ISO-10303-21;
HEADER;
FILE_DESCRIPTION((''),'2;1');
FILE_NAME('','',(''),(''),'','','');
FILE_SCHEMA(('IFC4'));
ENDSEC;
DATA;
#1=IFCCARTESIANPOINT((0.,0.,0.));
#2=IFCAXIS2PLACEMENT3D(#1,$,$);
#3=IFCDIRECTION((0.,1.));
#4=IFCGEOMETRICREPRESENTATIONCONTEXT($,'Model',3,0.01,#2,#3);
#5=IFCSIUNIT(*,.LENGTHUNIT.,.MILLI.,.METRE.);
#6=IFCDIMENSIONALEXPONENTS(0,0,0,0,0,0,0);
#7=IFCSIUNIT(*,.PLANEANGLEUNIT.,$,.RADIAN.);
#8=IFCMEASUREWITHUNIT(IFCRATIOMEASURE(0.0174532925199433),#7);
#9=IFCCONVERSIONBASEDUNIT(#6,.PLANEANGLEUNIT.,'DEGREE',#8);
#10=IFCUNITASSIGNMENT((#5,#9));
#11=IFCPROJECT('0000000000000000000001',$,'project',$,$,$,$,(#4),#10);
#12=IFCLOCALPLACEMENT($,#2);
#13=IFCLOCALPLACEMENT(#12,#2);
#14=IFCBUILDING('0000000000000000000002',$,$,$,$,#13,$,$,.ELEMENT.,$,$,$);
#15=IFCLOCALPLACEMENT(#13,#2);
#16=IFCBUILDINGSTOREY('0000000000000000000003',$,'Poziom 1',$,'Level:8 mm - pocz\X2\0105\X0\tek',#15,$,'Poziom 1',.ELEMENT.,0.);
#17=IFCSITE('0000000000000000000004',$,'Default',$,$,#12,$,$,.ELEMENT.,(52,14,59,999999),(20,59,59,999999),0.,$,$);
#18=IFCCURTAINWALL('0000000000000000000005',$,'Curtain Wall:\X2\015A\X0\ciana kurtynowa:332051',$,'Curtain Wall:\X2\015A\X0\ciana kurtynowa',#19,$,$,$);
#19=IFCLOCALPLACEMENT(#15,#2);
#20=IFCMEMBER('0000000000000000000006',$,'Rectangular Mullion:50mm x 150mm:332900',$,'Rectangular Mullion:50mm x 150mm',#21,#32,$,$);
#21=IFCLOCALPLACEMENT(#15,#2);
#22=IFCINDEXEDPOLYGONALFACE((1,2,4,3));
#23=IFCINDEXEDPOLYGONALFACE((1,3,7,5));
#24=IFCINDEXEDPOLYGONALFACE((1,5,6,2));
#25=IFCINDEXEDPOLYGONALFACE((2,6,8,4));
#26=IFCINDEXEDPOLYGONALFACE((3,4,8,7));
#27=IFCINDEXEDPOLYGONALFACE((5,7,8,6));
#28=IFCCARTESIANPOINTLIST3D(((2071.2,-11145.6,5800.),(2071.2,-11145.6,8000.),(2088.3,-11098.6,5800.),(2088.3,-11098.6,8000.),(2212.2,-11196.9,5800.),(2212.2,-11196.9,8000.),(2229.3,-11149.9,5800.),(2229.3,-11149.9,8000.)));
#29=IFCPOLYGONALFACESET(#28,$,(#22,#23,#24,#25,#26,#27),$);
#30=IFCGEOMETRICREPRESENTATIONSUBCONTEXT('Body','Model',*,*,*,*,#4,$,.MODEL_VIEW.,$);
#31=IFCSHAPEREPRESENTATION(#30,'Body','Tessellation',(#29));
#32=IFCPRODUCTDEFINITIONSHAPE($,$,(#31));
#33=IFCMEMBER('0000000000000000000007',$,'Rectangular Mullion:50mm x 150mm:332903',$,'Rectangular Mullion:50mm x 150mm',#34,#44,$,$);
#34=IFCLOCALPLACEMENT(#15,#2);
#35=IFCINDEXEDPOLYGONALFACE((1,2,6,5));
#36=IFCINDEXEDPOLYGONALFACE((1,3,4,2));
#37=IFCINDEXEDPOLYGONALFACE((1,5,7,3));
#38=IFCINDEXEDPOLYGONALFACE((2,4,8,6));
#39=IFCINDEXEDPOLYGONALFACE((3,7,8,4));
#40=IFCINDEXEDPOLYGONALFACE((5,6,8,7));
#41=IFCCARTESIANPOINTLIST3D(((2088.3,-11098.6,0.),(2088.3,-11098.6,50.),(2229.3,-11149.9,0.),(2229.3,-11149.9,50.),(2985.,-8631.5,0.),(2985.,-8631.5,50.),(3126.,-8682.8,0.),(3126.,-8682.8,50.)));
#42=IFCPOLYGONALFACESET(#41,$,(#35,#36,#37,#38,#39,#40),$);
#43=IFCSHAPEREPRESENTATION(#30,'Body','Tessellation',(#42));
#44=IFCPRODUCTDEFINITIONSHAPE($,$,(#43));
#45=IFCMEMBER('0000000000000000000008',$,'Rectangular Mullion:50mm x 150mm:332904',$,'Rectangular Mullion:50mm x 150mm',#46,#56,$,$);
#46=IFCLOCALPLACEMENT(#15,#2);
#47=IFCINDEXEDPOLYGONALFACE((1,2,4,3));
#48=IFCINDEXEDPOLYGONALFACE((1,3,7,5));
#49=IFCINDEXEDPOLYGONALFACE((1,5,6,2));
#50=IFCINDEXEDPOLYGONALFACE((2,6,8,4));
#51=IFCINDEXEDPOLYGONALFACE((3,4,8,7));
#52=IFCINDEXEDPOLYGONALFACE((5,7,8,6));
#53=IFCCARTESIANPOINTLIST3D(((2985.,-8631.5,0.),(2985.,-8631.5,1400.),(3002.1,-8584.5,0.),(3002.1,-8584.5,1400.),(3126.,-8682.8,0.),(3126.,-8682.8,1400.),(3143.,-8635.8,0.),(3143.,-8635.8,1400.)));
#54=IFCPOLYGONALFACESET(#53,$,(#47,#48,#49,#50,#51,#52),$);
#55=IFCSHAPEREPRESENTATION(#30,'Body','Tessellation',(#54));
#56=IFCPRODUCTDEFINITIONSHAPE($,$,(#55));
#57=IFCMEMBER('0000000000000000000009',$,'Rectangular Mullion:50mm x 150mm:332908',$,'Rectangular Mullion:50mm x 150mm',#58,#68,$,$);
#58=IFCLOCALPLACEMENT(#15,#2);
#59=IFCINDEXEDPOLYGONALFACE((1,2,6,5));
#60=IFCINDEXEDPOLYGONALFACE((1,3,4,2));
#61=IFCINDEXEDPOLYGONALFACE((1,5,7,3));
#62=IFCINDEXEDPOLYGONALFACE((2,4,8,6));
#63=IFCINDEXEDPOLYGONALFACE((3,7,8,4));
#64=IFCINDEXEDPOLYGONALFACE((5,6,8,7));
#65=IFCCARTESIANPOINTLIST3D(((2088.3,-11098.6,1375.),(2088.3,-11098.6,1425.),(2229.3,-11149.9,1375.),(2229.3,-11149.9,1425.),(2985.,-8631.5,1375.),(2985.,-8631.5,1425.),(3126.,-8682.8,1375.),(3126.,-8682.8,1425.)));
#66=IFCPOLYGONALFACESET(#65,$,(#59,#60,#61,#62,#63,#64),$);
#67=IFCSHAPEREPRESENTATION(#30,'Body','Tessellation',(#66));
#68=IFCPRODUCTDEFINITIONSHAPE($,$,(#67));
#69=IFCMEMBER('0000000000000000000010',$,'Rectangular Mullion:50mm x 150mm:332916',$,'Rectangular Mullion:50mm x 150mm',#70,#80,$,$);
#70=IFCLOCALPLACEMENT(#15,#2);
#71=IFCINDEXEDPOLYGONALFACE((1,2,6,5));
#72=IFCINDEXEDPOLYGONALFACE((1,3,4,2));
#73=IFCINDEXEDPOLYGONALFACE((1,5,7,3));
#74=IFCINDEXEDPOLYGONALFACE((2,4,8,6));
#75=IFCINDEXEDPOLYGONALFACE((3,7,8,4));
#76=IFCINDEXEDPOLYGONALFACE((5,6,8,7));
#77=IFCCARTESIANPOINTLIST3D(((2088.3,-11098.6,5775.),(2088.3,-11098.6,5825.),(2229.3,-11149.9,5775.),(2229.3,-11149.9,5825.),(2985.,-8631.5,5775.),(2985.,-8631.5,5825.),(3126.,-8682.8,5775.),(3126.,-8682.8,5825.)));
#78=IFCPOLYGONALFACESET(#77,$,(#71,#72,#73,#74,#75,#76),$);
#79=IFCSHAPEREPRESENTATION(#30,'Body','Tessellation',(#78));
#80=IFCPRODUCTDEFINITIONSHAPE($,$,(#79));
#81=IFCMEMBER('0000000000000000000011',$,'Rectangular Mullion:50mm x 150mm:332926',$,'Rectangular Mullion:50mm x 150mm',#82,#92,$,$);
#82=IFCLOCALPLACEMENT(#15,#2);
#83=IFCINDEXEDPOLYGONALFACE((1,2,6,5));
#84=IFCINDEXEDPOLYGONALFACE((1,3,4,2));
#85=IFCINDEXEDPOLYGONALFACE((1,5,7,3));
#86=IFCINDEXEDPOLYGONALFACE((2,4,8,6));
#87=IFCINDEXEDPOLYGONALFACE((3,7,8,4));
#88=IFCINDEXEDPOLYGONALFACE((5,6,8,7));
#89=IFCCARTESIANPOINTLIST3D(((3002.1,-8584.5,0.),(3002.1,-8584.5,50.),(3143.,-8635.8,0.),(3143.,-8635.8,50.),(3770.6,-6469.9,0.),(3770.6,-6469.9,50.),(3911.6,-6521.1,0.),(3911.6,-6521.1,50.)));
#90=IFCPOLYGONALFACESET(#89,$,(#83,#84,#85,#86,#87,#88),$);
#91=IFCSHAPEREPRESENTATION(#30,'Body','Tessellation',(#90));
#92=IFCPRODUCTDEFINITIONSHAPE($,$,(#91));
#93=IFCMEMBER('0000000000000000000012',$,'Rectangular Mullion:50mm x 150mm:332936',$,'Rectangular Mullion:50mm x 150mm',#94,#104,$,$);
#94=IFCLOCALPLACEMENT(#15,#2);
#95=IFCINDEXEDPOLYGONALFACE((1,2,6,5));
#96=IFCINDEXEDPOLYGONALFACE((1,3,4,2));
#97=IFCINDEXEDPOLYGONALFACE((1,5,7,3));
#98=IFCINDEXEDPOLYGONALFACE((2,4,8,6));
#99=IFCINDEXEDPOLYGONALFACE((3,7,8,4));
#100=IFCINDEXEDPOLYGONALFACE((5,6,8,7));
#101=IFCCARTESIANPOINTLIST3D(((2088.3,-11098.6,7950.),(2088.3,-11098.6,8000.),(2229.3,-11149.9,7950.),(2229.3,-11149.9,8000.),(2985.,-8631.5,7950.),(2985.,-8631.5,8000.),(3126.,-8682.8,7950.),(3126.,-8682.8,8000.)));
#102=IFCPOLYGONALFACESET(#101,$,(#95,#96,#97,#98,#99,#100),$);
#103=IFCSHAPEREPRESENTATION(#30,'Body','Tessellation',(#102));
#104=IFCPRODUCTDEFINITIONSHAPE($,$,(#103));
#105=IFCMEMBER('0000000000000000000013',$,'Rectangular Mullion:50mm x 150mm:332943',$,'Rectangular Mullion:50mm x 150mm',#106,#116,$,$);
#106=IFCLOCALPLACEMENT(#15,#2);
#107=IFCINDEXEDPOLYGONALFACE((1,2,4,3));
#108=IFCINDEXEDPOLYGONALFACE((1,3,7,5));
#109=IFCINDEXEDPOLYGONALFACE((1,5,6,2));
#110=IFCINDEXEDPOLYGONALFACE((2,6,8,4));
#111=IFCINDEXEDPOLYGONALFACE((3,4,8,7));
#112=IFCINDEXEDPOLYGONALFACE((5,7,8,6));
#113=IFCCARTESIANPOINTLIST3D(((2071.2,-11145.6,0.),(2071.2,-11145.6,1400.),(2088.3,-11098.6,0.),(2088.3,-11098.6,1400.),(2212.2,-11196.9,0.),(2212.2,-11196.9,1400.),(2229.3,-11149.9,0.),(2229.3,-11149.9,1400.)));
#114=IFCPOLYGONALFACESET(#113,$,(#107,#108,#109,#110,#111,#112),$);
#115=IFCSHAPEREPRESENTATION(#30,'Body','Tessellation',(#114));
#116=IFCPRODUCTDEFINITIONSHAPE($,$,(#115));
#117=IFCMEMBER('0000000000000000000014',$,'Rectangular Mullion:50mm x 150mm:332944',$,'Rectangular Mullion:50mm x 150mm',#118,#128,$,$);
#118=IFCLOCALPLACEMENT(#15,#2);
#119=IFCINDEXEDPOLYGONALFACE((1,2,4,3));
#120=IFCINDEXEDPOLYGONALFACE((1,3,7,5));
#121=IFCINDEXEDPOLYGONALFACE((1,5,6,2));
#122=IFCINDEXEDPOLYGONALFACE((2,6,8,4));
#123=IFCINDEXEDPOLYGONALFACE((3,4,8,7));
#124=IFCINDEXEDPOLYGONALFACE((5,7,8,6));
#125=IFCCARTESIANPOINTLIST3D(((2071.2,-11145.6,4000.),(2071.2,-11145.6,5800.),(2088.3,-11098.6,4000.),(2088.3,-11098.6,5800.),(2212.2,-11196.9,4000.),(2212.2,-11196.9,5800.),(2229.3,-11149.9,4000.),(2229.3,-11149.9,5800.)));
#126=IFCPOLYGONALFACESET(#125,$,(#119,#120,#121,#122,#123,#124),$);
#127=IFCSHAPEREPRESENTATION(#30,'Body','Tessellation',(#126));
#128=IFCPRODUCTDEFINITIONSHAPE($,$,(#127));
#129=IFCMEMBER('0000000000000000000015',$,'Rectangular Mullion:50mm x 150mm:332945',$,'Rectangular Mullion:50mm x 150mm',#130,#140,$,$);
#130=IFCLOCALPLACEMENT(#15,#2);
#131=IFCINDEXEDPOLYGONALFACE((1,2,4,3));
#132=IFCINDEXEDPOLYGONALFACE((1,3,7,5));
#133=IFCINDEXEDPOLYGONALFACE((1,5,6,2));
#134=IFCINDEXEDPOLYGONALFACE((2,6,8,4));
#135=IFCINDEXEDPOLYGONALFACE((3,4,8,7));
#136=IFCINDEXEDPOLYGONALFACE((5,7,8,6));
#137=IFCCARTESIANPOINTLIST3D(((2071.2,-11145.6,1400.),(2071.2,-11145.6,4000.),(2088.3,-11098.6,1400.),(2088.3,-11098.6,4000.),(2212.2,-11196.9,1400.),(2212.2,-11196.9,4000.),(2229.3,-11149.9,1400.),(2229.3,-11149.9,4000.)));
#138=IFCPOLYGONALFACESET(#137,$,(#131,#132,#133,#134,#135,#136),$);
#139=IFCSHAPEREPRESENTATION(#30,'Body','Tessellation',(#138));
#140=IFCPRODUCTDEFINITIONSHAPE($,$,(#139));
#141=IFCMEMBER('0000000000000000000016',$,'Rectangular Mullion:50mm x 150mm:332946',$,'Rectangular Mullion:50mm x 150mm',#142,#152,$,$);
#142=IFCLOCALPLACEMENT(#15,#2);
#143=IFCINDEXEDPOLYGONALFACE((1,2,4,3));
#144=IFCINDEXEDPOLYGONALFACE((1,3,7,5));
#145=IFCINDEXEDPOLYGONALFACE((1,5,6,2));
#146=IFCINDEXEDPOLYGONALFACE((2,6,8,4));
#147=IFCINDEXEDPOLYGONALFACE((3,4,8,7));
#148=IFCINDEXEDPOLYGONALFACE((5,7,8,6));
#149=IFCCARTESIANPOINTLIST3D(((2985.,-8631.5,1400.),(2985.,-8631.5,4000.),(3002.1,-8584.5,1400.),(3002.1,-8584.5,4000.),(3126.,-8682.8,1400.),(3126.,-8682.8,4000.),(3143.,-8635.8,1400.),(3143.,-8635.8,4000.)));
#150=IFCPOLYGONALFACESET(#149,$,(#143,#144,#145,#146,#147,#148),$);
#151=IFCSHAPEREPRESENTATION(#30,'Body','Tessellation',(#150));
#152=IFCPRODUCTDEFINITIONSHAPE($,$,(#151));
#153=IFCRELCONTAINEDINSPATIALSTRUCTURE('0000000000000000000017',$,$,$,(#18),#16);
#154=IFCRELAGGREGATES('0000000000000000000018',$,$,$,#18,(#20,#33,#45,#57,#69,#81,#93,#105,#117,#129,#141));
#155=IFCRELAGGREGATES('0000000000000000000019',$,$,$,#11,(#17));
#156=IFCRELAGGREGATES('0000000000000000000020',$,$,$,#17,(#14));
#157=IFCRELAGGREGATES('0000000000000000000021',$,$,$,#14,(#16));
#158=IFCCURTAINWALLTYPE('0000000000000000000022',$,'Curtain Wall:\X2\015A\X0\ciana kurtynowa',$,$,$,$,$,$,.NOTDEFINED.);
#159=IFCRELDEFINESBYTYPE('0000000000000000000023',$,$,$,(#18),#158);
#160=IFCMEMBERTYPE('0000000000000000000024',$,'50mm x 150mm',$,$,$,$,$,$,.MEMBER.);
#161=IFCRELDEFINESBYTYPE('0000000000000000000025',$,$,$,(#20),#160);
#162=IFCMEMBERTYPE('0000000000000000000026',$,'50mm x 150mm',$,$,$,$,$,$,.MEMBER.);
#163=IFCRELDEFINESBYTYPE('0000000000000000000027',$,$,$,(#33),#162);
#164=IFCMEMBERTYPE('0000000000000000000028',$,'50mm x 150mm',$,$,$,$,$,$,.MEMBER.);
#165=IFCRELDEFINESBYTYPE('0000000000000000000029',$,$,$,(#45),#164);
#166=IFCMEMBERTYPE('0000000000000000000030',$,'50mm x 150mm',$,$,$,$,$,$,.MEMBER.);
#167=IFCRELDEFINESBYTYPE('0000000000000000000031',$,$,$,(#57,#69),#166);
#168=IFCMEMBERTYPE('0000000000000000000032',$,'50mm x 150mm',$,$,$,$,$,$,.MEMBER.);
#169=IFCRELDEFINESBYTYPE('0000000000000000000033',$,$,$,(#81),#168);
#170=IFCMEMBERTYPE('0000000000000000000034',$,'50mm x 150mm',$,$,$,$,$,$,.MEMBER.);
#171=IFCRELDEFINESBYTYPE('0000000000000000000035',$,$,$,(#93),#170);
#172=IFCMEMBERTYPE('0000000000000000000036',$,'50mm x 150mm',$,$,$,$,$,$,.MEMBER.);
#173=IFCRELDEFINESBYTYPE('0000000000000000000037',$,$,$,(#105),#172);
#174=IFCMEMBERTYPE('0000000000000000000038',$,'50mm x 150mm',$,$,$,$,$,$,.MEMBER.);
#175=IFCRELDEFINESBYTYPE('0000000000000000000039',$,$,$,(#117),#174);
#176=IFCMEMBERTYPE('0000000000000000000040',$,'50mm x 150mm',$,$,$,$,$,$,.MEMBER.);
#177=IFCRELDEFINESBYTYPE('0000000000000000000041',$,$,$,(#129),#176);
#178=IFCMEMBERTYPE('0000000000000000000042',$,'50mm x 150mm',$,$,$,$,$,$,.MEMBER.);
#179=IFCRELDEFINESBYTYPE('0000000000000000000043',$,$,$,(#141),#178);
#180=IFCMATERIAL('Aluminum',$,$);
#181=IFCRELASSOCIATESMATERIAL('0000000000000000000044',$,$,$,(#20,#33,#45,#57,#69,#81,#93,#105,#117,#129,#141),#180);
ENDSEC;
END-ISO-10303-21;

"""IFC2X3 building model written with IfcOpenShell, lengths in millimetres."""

from ifc_helpers import new_model, entity, si_unit, converted_unit, direction, frame, origin, origin_2d_with_axis, place, context, subcontext, project, spatial, rectangle, extrude, source, transform, mapped, material, type_object, type_shapes, element, aggregate, save


model = new_model("IFC2X3")

# Units and contexts
model_context = context("Model", 3, precision=0.01, world=origin(), true_north=direction((0.0, 1.0)))
body_context = subcontext(model_context, "Body", "Model", "MODEL_VIEW")
ifc_project = project(units=[si_unit("LENGTHUNIT", "METRE", prefix="MILLI"), converted_unit("PLANEANGLEUNIT", "DEGREE", entity("IfcRatioMeasure", 0.0174532925199433), si_unit("PLANEANGLEUNIT", "RADIAN"), dimensions=[0, 0, 0, 0, 0, 0, 0])], contexts=[model_context])

# Site, building, storey
site_placement = place(None, origin())
site = spatial("IfcSite", under=ifc_project, at=site_placement, Name="Default", CompositionType="ELEMENT", RefLatitude=(52, 14, 59, 999999), RefLongitude=(20, 59, 59, 999999), RefElevation=0.0)
building_placement = place(site_placement, origin())
building = spatial("IfcBuilding", under=site, at=building_placement, CompositionType="ELEMENT")
storey_placement = place(building_placement, origin())
storey = spatial("IfcBuildingStorey", under=building, at=storey_placement, Name="Poziom 1", ObjectType="Level:8 mm - początek", LongName="Poziom 1", CompositionType="ELEMENT", Elevation=0.0)

# Curtain wall, members
curtain_wall_type = type_object("IfcCurtainWallType", Name="Curtain Wall:Ściana kurtynowa", PredefinedType="NOTDEFINED")
curtain_wall_placement = place(storey_placement, origin())
curtain_wall = element("IfcCurtainWall", 1, at=curtain_wall_placement, inside=storey, type_object=curtain_wall_type, Name="Curtain Wall:Ściana kurtynowa:332051", ObjectType="Curtain Wall:Ściana kurtynowa")
ifc_material_1 = material(Name="Aluminum")
member_type_1 = type_object("IfcMemberType", Name="50mm x 150mm", PredefinedType="MEMBER")
shared_shape_1 = source(origin(), body_context, "Body", "SweptSolid", [
    extrude(rectangle(XDim=150.0, YDim=50.0, at=origin_2d_with_axis()), frame((-25.0, 0.0, -2200.0), z_axis=(0.0, 0.0, 1.0), x_axis=(0.0, -1.0, 0.0)), (0.0, 0.0, 1.0), 2200.0),
])
type_shapes(member_type_1, [shared_shape_1])
member_1_placement = place(storey_placement, frame((2141.7, -11171.2, 8000.0), z_axis=(0.0, 0.0, 1.0), x_axis=(-0.341586, -0.939851, 0.0)))
member_1 = element("IfcMember", 2, at=member_1_placement, type_object=member_type_1, material=ifc_material_1, Name="Rectangular Mullion:50mm x 150mm:332900", ObjectType="Rectangular Mullion:50mm x 150mm", context=body_context, shape_type="MappedRepresentation", body=[
    mapped(shared_shape_1, transform((0.0, 0.0, 0.0), scale=1.0)),
])
member_type_2 = type_object("IfcMemberType", Name="50mm x 150mm", PredefinedType="MEMBER")
shared_shape_2 = source(origin(), body_context, "Body", "SweptSolid", [
    extrude(rectangle(XDim=150.0, YDim=50.0, at=origin_2d_with_axis()), frame((-25.0, 0.0, -2625.0), z_axis=(0.0, 0.0, 1.0), x_axis=(0.0, -1.0, 0.0)), (0.0, 0.0, 1.0), 2625.0),
])
type_shapes(member_type_2, [shared_shape_2])
member_2_placement = place(storey_placement, frame((2158.8, -11124.3, 0.0), z_axis=(-0.341586, -0.939851, 0.0), x_axis=(0.0, 0.0, -1.0)))
member_2 = element("IfcMember", 3, at=member_2_placement, type_object=member_type_2, material=ifc_material_1, Name="Rectangular Mullion:50mm x 150mm:332903", ObjectType="Rectangular Mullion:50mm x 150mm", context=body_context, shape_type="MappedRepresentation", body=[
    mapped(shared_shape_2, transform((0.0, 0.0, 0.0), scale=1.0)),
])
member_type_3 = type_object("IfcMemberType", Name="50mm x 150mm", PredefinedType="MEMBER")
shared_shape_3 = source(origin(), body_context, "Body", "SweptSolid", [
    extrude(rectangle(XDim=150.0, YDim=50.0, at=origin_2d_with_axis()), frame((0.0, 0.0, -1400.0), z_axis=(0.0, 0.0, 1.0), x_axis=(0.0, -1.0, 0.0)), (0.0, 0.0, 1.0), 1400.0),
])
type_shapes(member_type_3, [shared_shape_3])
member_3_placement = place(storey_placement, frame((3064.0, -8633.7, 0.0), z_axis=(0.0, 0.0, -1.0), x_axis=(0.341586, 0.939851, 0.0)))
member_3 = element("IfcMember", 4, at=member_3_placement, type_object=member_type_3, material=ifc_material_1, Name="Rectangular Mullion:50mm x 150mm:332904", ObjectType="Rectangular Mullion:50mm x 150mm", context=body_context, shape_type="MappedRepresentation", body=[
    mapped(shared_shape_3, transform((0.0, 0.0, 0.0), scale=1.0)),
])
member_type_4 = type_object("IfcMemberType", Name="50mm x 150mm", PredefinedType="MEMBER")
shared_shape_4 = source(origin(), body_context, "Body", "SweptSolid", [
    extrude(rectangle(XDim=150.0, YDim=50.0, at=origin_2d_with_axis()), frame((0.0, 0.0, -2625.0), z_axis=(0.0, 0.0, 1.0), x_axis=(0.0, -1.0, 0.0)), (0.0, 0.0, 1.0), 2625.0),
])
type_shapes(member_type_4, [shared_shape_4])
member_4_placement = place(storey_placement, frame((3055.5, -8657.1, 1400.0), z_axis=(0.341586, 0.939851, 0.0), x_axis=(0.0, 0.0, 1.0)))
member_4 = element("IfcMember", 5, at=member_4_placement, type_object=member_type_4, material=ifc_material_1, Name="Rectangular Mullion:50mm x 150mm:332908", ObjectType="Rectangular Mullion:50mm x 150mm", context=body_context, shape_type="MappedRepresentation", body=[
    mapped(shared_shape_4, transform((0.0, 0.0, 0.0), scale=1.0)),
])
member_5_placement = place(storey_placement, frame((3055.5, -8657.1, 5800.0), z_axis=(0.341586, 0.939851, 0.0), x_axis=(0.0, 0.0, 1.0)))
member_5 = element("IfcMember", 6, at=member_5_placement, type_object=member_type_4, material=ifc_material_1, Name="Rectangular Mullion:50mm x 150mm:332916", ObjectType="Rectangular Mullion:50mm x 150mm", context=body_context, shape_type="MappedRepresentation", body=[
    mapped(shared_shape_4, transform((0.0, 0.0, 0.0), scale=1.0)),
])
member_type_5 = type_object("IfcMemberType", Name="50mm x 150mm", PredefinedType="MEMBER")
shared_shape_5 = source(origin(), body_context, "Body", "SweptSolid", [
    extrude(rectangle(XDim=150.0, YDim=50.0, at=origin_2d_with_axis()), frame((-25.0, 0.0, -2250.0), z_axis=(0.0, 0.0, 1.0), x_axis=(0.0, -1.0, 0.0)), (0.0, 0.0, 1.0), 2250.0),
])
type_shapes(member_type_5, [shared_shape_5])
member_6_placement = place(storey_placement, frame((3072.5, -8610.2, 0.0), z_axis=(-0.341586, -0.939851, 0.0), x_axis=(0.0, 0.0, -1.0)))
member_6 = element("IfcMember", 7, at=member_6_placement, type_object=member_type_5, material=ifc_material_1, Name="Rectangular Mullion:50mm x 150mm:332926", ObjectType="Rectangular Mullion:50mm x 150mm", context=body_context, shape_type="MappedRepresentation", body=[
    mapped(shared_shape_5, transform((0.0, 0.0, 0.0), scale=1.0)),
])
member_type_6 = type_object("IfcMemberType", Name="50mm x 150mm", PredefinedType="MEMBER")
shared_shape_6 = source(origin(), body_context, "Body", "SweptSolid", [
    extrude(rectangle(XDim=150.0, YDim=50.0, at=origin_2d_with_axis()), frame((-25.0, 0.0, -2625.0), z_axis=(0.0, 0.0, 1.0), x_axis=(0.0, -1.0, 0.0)), (0.0, 0.0, 1.0), 2625.0),
])
type_shapes(member_type_6, [shared_shape_6])
member_7_placement = place(storey_placement, frame((3055.5, -8657.1, 8000.0), z_axis=(0.341586, 0.939851, 0.0), x_axis=(0.0, 0.0, 1.0)))
member_7 = element("IfcMember", 8, at=member_7_placement, type_object=member_type_6, material=ifc_material_1, Name="Rectangular Mullion:50mm x 150mm:332936", ObjectType="Rectangular Mullion:50mm x 150mm", context=body_context, shape_type="MappedRepresentation", body=[
    mapped(shared_shape_6, transform((0.0, 0.0, 0.0), scale=1.0)),
])
member_type_7 = type_object("IfcMemberType", Name="50mm x 150mm", PredefinedType="MEMBER")
shared_shape_7 = source(origin(), body_context, "Body", "SweptSolid", [
    extrude(rectangle(XDim=150.0, YDim=50.0, at=origin_2d_with_axis()), frame((-25.0, 0.0, -1400.0), z_axis=(0.0, 0.0, 1.0), x_axis=(0.0, -1.0, 0.0)), (0.0, 0.0, 1.0), 1400.0),
])
type_shapes(member_type_7, [shared_shape_7])
member_8_placement = place(storey_placement, frame((2141.7, -11171.2, 1400.0), z_axis=(0.0, 0.0, 1.0), x_axis=(-0.341586, -0.939851, 0.0)))
member_8 = element("IfcMember", 9, at=member_8_placement, type_object=member_type_7, material=ifc_material_1, Name="Rectangular Mullion:50mm x 150mm:332943", ObjectType="Rectangular Mullion:50mm x 150mm", context=body_context, shape_type="MappedRepresentation", body=[
    mapped(shared_shape_7, transform((0.0, 0.0, 0.0), scale=1.0)),
])
member_type_8 = type_object("IfcMemberType", Name="50mm x 150mm", PredefinedType="MEMBER")
shared_shape_8 = source(origin(), body_context, "Body", "SweptSolid", [
    extrude(rectangle(XDim=150.0, YDim=50.0, at=origin_2d_with_axis()), frame((-25.0, 0.0, -1800.0), z_axis=(0.0, 0.0, 1.0), x_axis=(0.0, -1.0, 0.0)), (0.0, 0.0, 1.0), 1800.0),
])
type_shapes(member_type_8, [shared_shape_8])
member_9_placement = place(storey_placement, frame((2141.7, -11171.2, 5800.0), z_axis=(0.0, 0.0, 1.0), x_axis=(-0.341586, -0.939851, 0.0)))
member_9 = element("IfcMember", 10, at=member_9_placement, type_object=member_type_8, material=ifc_material_1, Name="Rectangular Mullion:50mm x 150mm:332944", ObjectType="Rectangular Mullion:50mm x 150mm", context=body_context, shape_type="MappedRepresentation", body=[
    mapped(shared_shape_8, transform((0.0, 0.0, 0.0), scale=1.0)),
])
member_type_9 = type_object("IfcMemberType", Name="50mm x 150mm", PredefinedType="MEMBER")
shared_shape_9 = source(origin(), body_context, "Body", "SweptSolid", [
    extrude(rectangle(XDim=150.0, YDim=50.0, at=origin_2d_with_axis()), frame((-25.0, 0.0, -2600.0), z_axis=(0.0, 0.0, 1.0), x_axis=(0.0, -1.0, 0.0)), (0.0, 0.0, 1.0), 2600.0),
])
type_shapes(member_type_9, [shared_shape_9])
member_10_placement = place(storey_placement, frame((2141.7, -11171.2, 4000.0), z_axis=(0.0, 0.0, 1.0), x_axis=(-0.341586, -0.939851, 0.0)))
member_10 = element("IfcMember", 11, at=member_10_placement, type_object=member_type_9, material=ifc_material_1, Name="Rectangular Mullion:50mm x 150mm:332945", ObjectType="Rectangular Mullion:50mm x 150mm", context=body_context, shape_type="MappedRepresentation", body=[
    mapped(shared_shape_9, transform((0.0, 0.0, 0.0), scale=1.0)),
])
member_type_10 = type_object("IfcMemberType", Name="50mm x 150mm", PredefinedType="MEMBER")
shared_shape_10 = source(origin(), body_context, "Body", "SweptSolid", [
    extrude(rectangle(XDim=150.0, YDim=50.0, at=origin_2d_with_axis()), frame((0.0, 0.0, -2600.0), z_axis=(0.0, 0.0, 1.0), x_axis=(0.0, -1.0, 0.0)), (0.0, 0.0, 1.0), 2600.0),
])
type_shapes(member_type_10, [shared_shape_10])
member_11_placement = place(storey_placement, frame((3064.0, -8633.7, 1400.0), z_axis=(0.0, 0.0, -1.0), x_axis=(0.341586, 0.939851, 0.0)))
member_11 = element("IfcMember", 12, at=member_11_placement, type_object=member_type_10, material=ifc_material_1, Name="Rectangular Mullion:50mm x 150mm:332946", ObjectType="Rectangular Mullion:50mm x 150mm", context=body_context, shape_type="MappedRepresentation", body=[
    mapped(shared_shape_10, transform((0.0, 0.0, 0.0), scale=1.0)),
])
aggregate(curtain_wall, [member_1, member_2, member_3, member_4, member_5, member_6, member_7, member_8, member_9, member_10, member_11])

save(model, "model.ifc")
